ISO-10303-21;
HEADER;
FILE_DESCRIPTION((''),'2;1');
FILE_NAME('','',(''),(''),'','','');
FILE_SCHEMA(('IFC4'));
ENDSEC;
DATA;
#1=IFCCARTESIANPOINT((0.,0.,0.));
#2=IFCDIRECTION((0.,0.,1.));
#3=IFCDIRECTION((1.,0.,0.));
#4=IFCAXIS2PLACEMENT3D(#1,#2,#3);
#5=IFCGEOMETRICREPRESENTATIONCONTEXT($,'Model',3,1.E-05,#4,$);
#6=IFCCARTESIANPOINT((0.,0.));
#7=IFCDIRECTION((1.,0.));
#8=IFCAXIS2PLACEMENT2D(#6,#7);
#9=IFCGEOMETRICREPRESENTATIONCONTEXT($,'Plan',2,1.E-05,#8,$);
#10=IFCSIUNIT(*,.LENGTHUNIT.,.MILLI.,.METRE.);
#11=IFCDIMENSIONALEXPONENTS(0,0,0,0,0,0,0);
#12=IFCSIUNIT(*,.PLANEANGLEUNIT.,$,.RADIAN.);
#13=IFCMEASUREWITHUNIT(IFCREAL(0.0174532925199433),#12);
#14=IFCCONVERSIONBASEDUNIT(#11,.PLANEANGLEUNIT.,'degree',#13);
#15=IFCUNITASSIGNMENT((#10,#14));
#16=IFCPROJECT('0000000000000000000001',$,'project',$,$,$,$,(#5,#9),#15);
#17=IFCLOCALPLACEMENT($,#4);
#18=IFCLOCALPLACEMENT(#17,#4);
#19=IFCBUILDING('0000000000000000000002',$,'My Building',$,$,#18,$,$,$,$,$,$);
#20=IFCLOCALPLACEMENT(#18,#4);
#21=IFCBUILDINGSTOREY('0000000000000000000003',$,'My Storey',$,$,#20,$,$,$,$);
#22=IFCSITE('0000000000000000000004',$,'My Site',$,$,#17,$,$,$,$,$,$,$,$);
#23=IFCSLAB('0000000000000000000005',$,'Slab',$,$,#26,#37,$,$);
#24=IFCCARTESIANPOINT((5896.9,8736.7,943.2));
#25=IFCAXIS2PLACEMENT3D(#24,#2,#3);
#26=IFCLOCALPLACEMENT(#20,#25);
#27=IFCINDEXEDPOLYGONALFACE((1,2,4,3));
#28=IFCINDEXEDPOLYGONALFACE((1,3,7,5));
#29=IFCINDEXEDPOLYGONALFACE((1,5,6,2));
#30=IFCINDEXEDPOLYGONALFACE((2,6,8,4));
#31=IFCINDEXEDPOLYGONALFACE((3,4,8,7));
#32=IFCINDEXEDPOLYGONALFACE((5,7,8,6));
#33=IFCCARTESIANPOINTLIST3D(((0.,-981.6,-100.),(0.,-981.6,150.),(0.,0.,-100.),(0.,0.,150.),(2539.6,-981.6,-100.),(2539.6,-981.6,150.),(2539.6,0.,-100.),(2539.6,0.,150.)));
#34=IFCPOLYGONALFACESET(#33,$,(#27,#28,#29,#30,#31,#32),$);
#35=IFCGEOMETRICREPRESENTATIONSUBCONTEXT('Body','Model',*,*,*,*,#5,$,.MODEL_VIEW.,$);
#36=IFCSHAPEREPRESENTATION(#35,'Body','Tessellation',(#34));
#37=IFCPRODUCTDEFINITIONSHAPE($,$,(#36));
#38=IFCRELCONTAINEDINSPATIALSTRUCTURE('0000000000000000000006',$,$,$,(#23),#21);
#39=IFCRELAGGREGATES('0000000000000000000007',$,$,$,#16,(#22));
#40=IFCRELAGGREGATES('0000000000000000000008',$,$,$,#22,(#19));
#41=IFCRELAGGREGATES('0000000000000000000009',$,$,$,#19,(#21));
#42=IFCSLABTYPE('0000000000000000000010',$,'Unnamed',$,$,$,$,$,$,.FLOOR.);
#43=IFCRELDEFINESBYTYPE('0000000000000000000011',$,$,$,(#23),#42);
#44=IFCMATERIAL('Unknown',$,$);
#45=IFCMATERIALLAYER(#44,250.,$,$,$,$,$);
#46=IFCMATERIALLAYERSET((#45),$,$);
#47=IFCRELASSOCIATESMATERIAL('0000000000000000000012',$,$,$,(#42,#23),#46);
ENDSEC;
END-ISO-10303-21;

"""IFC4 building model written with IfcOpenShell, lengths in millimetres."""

from ifc_helpers import new_model, entity, si_unit, converted_unit, frame, origin_with_axes, origin_2d_with_axis, place, context, subcontext, project, spatial, indexed_curve, outline, extrude, material, layer, layer_set, layer_usage, type_object, element, save


model = new_model("IFC4")

# Units and contexts
model_context = context("Model", 3, precision=1e-05, world=origin_with_axes())
plan_context = context("Plan", 2, precision=1e-05, world=origin_2d_with_axis())
body_context = subcontext(model_context, "Body", "Model", "MODEL_VIEW")
ifc_project = project(units=[si_unit("LENGTHUNIT", "METRE", prefix="MILLI"), converted_unit("PLANEANGLEUNIT", "degree", entity("IfcReal", 0.0174532925199433), si_unit("PLANEANGLEUNIT", "RADIAN"), dimensions=[0, 0, 0, 0, 0, 0, 0])], contexts=[model_context, plan_context])

# Site, building, storey
site_placement = place(None, origin_with_axes())
site = spatial("IfcSite", under=ifc_project, at=site_placement, Name="My Site")
building_placement = place(site_placement, origin_with_axes())
building = spatial("IfcBuilding", under=site, at=building_placement, Name="My Building")
storey_placement = place(building_placement, origin_with_axes())
storey = spatial("IfcBuildingStorey", under=building, at=storey_placement, Name="My Storey")

# Shared definitions
ifc_material = material(Name="Unknown")

# Slab
ifc_layer_1 = layer(ifc_material, 250.0)
ifc_layer_set_1 = layer_set([ifc_layer_1])
ifc_layer_usage_1 = layer_usage(ifc_layer_set_1, "AXIS3", "POSITIVE", -100.0)
slab_type = type_object("IfcSlabType", Name="Unnamed", PredefinedType="FLOOR", material=ifc_layer_set_1)
slab_placement = place(storey_placement, frame((5896.9, 8736.7, 943.2), z_axis=(0.0, 0.0, 1.0), x_axis=(1.0, 0.0, 0.0)))
element("IfcSlab", 1, at=slab_placement, inside=storey, type_object=slab_type, material=ifc_layer_usage_1, Name="Slab", context=body_context, shape_type="SweptSolid", body=[
    extrude(outline(indexed_curve([(0.0, 0.0), (2539.6, 0.0), (2539.6, -981.6), (0.0, -981.6), (0.0, 0.0)])), frame((0.0, 0.0, -100.0), z_axis=(0.0, 0.0, 1.0), x_axis=(1.0, 0.0, 0.0)), (0.0, 0.0, 1.0), 250.0),
])

save(model, "model.ifc")
